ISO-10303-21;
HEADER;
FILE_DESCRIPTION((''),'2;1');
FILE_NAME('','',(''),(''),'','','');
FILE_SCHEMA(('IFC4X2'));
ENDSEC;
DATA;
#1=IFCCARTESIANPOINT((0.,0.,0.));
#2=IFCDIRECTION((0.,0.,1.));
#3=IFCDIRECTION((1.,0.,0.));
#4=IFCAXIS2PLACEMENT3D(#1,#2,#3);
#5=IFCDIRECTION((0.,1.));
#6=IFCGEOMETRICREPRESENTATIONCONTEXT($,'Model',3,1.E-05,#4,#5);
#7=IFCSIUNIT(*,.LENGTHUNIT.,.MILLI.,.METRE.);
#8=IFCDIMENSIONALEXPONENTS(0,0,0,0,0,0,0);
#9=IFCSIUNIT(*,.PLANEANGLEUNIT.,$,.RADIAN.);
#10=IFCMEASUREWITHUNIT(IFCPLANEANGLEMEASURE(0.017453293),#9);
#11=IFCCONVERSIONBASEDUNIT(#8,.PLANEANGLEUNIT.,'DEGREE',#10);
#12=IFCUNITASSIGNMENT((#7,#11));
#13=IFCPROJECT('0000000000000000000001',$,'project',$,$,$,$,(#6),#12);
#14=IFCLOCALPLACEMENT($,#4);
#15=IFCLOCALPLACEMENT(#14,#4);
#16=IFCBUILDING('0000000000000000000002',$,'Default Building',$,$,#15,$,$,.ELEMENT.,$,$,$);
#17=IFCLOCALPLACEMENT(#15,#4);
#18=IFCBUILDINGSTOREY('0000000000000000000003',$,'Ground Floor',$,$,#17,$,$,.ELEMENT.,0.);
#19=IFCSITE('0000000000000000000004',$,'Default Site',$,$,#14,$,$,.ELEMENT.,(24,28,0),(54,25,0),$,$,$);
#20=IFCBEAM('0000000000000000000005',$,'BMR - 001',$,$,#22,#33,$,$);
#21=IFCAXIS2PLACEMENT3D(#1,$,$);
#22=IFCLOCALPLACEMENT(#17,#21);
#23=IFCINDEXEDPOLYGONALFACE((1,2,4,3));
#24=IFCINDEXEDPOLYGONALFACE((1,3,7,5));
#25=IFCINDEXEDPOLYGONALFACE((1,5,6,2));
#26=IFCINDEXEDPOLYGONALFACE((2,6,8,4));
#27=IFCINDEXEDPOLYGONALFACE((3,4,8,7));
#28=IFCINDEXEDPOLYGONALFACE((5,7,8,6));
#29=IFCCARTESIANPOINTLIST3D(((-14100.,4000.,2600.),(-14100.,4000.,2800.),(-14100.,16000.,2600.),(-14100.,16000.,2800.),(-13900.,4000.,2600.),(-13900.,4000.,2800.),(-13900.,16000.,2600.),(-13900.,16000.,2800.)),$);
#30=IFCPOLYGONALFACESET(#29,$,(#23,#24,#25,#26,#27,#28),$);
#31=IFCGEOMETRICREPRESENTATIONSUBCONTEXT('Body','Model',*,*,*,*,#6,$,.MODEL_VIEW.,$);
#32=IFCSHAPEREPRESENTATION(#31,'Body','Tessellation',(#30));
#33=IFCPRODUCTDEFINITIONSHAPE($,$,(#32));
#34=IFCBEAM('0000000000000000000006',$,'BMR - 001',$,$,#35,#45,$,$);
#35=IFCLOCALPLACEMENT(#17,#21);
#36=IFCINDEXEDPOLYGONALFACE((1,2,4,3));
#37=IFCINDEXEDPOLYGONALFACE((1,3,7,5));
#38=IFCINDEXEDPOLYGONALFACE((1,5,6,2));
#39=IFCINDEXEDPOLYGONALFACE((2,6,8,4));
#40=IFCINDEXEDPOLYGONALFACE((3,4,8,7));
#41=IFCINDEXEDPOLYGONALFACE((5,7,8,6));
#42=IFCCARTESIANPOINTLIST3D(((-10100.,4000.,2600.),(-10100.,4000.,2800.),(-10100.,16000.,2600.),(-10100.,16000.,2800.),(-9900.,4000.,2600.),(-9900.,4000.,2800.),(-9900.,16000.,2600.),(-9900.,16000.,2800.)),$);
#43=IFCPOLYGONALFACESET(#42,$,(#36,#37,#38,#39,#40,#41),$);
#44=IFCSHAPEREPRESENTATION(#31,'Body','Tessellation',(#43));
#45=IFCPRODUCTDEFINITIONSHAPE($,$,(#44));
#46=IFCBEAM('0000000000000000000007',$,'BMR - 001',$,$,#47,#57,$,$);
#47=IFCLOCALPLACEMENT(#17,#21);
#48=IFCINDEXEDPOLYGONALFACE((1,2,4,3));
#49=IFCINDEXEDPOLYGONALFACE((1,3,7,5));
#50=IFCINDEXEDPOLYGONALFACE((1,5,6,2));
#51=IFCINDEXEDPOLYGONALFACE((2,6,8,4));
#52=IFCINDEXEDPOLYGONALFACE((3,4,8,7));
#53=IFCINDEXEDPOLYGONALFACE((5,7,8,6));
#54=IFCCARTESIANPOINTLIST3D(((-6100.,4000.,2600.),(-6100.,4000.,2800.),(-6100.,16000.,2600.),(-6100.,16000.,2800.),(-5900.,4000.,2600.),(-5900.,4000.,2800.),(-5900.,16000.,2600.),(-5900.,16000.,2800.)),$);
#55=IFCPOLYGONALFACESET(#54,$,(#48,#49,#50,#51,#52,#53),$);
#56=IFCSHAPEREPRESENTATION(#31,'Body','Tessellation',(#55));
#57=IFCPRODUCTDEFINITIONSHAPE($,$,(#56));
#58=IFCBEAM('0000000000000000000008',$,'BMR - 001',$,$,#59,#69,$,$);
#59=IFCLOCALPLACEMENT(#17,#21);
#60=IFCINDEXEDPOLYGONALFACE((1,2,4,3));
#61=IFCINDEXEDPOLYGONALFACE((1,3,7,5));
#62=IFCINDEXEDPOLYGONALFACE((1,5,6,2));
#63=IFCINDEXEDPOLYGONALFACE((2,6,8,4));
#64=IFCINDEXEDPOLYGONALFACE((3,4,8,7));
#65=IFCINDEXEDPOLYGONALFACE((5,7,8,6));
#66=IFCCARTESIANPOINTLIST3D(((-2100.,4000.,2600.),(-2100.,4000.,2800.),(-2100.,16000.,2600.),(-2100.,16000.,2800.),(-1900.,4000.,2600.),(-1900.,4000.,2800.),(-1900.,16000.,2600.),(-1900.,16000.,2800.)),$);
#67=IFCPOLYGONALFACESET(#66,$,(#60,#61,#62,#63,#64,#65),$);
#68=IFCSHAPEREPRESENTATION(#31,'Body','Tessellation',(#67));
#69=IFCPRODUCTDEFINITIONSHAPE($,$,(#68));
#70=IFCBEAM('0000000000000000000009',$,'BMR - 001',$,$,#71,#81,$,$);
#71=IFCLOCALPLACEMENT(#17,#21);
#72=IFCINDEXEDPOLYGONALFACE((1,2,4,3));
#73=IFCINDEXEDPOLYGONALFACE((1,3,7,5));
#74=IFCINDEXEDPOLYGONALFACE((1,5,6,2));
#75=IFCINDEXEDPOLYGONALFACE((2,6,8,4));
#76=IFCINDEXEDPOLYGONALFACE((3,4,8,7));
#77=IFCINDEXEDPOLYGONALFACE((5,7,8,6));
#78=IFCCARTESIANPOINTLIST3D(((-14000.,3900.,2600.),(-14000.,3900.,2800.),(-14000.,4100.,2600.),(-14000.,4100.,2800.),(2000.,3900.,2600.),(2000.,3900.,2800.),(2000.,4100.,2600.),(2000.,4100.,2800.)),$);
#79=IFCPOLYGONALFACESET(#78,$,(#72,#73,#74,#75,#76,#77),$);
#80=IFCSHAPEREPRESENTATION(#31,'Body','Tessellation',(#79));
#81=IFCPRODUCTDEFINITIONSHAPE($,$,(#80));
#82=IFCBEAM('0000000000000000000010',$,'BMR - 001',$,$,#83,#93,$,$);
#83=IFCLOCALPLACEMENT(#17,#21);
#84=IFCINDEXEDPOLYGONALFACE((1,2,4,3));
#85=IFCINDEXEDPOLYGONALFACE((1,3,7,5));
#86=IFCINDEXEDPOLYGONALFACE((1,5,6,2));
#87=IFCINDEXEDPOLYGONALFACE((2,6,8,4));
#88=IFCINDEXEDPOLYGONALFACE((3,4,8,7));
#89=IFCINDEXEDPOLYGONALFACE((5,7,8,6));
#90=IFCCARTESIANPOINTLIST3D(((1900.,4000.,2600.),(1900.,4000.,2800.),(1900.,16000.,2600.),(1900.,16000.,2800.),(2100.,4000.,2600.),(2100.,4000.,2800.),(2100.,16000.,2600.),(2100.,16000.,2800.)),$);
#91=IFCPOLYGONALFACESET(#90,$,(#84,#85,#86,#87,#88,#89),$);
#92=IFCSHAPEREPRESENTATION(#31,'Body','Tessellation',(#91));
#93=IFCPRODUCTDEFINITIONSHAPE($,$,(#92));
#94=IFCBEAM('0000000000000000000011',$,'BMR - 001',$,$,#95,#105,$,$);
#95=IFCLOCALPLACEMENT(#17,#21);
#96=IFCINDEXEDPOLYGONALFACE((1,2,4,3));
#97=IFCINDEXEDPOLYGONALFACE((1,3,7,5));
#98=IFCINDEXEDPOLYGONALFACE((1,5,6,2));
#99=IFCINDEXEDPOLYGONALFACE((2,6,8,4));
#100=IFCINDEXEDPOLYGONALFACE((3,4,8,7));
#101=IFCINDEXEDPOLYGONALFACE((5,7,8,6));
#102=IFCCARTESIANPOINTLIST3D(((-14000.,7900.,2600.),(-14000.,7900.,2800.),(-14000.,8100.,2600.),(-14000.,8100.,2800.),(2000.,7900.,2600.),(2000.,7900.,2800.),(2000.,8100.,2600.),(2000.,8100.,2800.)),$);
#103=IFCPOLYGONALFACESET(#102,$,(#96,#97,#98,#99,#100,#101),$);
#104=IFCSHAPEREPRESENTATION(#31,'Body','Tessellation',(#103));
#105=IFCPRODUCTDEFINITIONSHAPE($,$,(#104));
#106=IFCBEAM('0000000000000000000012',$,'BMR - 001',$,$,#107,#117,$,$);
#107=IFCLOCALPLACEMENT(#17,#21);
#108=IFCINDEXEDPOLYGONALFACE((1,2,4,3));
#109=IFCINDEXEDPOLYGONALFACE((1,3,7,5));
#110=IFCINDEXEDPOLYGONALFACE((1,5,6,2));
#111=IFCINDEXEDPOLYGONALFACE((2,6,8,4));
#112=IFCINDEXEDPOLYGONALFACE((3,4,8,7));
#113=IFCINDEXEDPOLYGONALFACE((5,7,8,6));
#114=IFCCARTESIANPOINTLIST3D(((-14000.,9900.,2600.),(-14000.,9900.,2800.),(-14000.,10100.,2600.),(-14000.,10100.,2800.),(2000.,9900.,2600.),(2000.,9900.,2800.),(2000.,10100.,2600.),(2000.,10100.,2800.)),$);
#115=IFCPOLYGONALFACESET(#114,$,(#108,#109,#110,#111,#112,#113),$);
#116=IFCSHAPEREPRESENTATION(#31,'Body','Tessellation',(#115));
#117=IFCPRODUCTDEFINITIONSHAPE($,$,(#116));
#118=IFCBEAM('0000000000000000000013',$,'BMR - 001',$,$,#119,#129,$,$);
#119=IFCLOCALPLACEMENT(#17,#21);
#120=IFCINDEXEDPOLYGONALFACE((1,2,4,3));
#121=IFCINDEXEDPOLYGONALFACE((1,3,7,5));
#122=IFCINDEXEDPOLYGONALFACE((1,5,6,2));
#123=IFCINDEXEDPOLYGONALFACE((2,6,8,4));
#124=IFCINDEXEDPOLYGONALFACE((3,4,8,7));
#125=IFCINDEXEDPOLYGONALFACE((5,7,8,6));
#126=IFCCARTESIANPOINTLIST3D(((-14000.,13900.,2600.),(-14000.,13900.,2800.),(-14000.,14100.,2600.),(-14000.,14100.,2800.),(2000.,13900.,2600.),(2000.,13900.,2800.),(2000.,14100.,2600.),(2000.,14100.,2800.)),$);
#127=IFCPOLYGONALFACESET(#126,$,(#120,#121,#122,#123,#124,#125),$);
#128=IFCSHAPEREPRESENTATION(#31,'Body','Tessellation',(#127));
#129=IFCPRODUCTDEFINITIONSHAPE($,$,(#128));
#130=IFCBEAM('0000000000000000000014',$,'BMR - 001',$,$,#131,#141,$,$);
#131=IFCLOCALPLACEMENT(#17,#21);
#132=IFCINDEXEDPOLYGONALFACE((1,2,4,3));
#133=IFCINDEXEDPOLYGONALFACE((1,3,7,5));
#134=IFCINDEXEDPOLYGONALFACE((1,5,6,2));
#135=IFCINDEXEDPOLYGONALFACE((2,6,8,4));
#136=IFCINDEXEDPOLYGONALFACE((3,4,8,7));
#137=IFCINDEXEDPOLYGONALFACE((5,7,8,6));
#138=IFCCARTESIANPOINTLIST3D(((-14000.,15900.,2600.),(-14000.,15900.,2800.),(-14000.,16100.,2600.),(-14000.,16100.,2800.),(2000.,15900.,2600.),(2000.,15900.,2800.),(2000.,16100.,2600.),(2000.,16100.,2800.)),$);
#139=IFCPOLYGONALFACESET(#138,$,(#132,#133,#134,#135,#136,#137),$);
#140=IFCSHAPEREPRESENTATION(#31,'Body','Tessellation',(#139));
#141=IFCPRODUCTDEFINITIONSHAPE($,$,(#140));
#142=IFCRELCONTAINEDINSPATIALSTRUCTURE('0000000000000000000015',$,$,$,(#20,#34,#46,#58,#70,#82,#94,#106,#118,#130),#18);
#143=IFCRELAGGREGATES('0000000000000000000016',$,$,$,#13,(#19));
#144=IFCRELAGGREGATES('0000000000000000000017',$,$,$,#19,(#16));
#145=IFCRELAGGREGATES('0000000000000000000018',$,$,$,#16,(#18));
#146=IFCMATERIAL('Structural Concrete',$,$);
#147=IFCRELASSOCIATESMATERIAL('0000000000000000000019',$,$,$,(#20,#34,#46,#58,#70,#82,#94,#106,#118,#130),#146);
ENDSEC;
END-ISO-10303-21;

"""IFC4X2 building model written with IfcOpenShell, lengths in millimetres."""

from ifc_helpers import new_model, entity, si_unit, converted_unit, direction, frame, frame_2d, origin_with_axes, place, context, subcontext, project, spatial, rectangle, extrude, material, element, save


model = new_model("IFC4X2")

# Units and contexts
model_context = context("Model", 3, precision=1e-05, world=origin_with_axes(), true_north=direction((0.0, 1.0)))
body_context = subcontext(model_context, "Body", "Model", "MODEL_VIEW")
ifc_project = project(units=[si_unit("LENGTHUNIT", "METRE", prefix="MILLI"), converted_unit("PLANEANGLEUNIT", "DEGREE", entity("IfcPlaneAngleMeasure", 0.017453293), si_unit("PLANEANGLEUNIT", "RADIAN"), dimensions=[0, 0, 0, 0, 0, 0, 0])], contexts=[model_context])

# Site, building, storey
site_placement = place(None, origin_with_axes())
site = spatial("IfcSite", under=ifc_project, at=site_placement, Name="Default Site", CompositionType="ELEMENT", RefLatitude=(24, 28, 0), RefLongitude=(54, 25, 0))
building_placement = place(site_placement, origin_with_axes())
building = spatial("IfcBuilding", under=site, at=building_placement, Name="Default Building", CompositionType="ELEMENT")
storey_placement = place(building_placement, origin_with_axes())
storey = spatial("IfcBuildingStorey", under=building, at=storey_placement, Name="Ground Floor", CompositionType="ELEMENT", Elevation=0.0)

# Beams
ifc_material = material(Name="Structural Concrete")
for number, where, z_axis, x_axis, name in (
    (1, (-14000.0, 4000.0, 2800.0), (0.0, 0.0, 1.0), (1.0, 0.0, 0.0), "BMR - 001"),
    (2, (-10000.0, 4000.0, 2800.0), (0.0, 0.0, 1.0), (1.0, 0.0, 0.0), "BMR - 001"),
    (3, (-6000.0, 4000.0, 2800.0), (0.0, 0.0, 1.0), (1.0, 0.0, 0.0), "BMR - 001"),
    (4, (-2000.0, 4000.0, 2800.0), (0.0, 0.0, 1.0), (1.0, 0.0, 0.0), "BMR - 001"),
):
    element("IfcBeam", number, at=place(storey_placement, frame(where, z_axis=z_axis, x_axis=x_axis)), inside=storey, material=ifc_material, Name=name, context=body_context, shape_type="SweptSolid", body=[
        extrude(rectangle(XDim=200.0, YDim=200.0, at=frame_2d((-100.0, 0.0), x_axis=(1.0, 0.0))), frame((0.0, 0.0, 0.0), z_axis=(0.0, 1.0, 0.0), x_axis=(0.0, 0.0, 1.0)), (0.0, 0.0, 1.0), 12000.0),
    ])
beam_1_placement = place(storey_placement, frame((-14000.0, 4000.0, 2800.0), z_axis=(0.0, 0.0, 1.0), x_axis=(0.0, -1.0, 0.0)))
element("IfcBeam", 5, at=beam_1_placement, inside=storey, material=ifc_material, Name="BMR - 001", context=body_context, shape_type="SweptSolid", body=[
    extrude(rectangle(XDim=200.0, YDim=200.0, at=frame_2d((-100.0, 0.0), x_axis=(1.0, 0.0))), frame((0.0, 0.0, 0.0), z_axis=(0.0, 1.0, 0.0), x_axis=(0.0, 0.0, 1.0)), (0.0, 0.0, 1.0), 16000.0),
])
beam_2_placement = place(storey_placement, frame((2000.0, 4000.0, 2800.0), z_axis=(0.0, 0.0, 1.0), x_axis=(1.0, 0.0, 0.0)))
element("IfcBeam", 6, at=beam_2_placement, inside=storey, material=ifc_material, Name="BMR - 001", context=body_context, shape_type="SweptSolid", body=[
    extrude(rectangle(XDim=200.0, YDim=200.0, at=frame_2d((-100.0, 0.0), x_axis=(1.0, 0.0))), frame((0.0, 0.0, 0.0), z_axis=(0.0, 1.0, 0.0), x_axis=(0.0, 0.0, 1.0)), (0.0, 0.0, 1.0), 12000.0),
])
for number, where, z_axis, x_axis, name in (
    (7, (-14000.0, 8000.0, 2800.0), (0.0, 0.0, 1.0), (0.0, -1.0, 0.0), "BMR - 001"),
    (8, (-14000.0, 10000.0, 2800.0), (0.0, 0.0, 1.0), (0.0, -1.0, 0.0), "BMR - 001"),
    (9, (-14000.0, 14000.0, 2800.0), (0.0, 0.0, 1.0), (0.0, -1.0, 0.0), "BMR - 001"),
    (10, (-14000.0, 16000.0, 2800.0), (0.0, 0.0, 1.0), (0.0, -1.0, 0.0), "BMR - 001"),
):
    element("IfcBeam", number, at=place(storey_placement, frame(where, z_axis=z_axis, x_axis=x_axis)), inside=storey, material=ifc_material, Name=name, context=body_context, shape_type="SweptSolid", body=[
        extrude(rectangle(XDim=200.0, YDim=200.0, at=frame_2d((-100.0, 0.0), x_axis=(1.0, 0.0))), frame((0.0, 0.0, 0.0), z_axis=(0.0, 1.0, 0.0), x_axis=(0.0, 0.0, 1.0)), (0.0, 0.0, 1.0), 16000.0),
    ])

save(model, "model.ifc")
